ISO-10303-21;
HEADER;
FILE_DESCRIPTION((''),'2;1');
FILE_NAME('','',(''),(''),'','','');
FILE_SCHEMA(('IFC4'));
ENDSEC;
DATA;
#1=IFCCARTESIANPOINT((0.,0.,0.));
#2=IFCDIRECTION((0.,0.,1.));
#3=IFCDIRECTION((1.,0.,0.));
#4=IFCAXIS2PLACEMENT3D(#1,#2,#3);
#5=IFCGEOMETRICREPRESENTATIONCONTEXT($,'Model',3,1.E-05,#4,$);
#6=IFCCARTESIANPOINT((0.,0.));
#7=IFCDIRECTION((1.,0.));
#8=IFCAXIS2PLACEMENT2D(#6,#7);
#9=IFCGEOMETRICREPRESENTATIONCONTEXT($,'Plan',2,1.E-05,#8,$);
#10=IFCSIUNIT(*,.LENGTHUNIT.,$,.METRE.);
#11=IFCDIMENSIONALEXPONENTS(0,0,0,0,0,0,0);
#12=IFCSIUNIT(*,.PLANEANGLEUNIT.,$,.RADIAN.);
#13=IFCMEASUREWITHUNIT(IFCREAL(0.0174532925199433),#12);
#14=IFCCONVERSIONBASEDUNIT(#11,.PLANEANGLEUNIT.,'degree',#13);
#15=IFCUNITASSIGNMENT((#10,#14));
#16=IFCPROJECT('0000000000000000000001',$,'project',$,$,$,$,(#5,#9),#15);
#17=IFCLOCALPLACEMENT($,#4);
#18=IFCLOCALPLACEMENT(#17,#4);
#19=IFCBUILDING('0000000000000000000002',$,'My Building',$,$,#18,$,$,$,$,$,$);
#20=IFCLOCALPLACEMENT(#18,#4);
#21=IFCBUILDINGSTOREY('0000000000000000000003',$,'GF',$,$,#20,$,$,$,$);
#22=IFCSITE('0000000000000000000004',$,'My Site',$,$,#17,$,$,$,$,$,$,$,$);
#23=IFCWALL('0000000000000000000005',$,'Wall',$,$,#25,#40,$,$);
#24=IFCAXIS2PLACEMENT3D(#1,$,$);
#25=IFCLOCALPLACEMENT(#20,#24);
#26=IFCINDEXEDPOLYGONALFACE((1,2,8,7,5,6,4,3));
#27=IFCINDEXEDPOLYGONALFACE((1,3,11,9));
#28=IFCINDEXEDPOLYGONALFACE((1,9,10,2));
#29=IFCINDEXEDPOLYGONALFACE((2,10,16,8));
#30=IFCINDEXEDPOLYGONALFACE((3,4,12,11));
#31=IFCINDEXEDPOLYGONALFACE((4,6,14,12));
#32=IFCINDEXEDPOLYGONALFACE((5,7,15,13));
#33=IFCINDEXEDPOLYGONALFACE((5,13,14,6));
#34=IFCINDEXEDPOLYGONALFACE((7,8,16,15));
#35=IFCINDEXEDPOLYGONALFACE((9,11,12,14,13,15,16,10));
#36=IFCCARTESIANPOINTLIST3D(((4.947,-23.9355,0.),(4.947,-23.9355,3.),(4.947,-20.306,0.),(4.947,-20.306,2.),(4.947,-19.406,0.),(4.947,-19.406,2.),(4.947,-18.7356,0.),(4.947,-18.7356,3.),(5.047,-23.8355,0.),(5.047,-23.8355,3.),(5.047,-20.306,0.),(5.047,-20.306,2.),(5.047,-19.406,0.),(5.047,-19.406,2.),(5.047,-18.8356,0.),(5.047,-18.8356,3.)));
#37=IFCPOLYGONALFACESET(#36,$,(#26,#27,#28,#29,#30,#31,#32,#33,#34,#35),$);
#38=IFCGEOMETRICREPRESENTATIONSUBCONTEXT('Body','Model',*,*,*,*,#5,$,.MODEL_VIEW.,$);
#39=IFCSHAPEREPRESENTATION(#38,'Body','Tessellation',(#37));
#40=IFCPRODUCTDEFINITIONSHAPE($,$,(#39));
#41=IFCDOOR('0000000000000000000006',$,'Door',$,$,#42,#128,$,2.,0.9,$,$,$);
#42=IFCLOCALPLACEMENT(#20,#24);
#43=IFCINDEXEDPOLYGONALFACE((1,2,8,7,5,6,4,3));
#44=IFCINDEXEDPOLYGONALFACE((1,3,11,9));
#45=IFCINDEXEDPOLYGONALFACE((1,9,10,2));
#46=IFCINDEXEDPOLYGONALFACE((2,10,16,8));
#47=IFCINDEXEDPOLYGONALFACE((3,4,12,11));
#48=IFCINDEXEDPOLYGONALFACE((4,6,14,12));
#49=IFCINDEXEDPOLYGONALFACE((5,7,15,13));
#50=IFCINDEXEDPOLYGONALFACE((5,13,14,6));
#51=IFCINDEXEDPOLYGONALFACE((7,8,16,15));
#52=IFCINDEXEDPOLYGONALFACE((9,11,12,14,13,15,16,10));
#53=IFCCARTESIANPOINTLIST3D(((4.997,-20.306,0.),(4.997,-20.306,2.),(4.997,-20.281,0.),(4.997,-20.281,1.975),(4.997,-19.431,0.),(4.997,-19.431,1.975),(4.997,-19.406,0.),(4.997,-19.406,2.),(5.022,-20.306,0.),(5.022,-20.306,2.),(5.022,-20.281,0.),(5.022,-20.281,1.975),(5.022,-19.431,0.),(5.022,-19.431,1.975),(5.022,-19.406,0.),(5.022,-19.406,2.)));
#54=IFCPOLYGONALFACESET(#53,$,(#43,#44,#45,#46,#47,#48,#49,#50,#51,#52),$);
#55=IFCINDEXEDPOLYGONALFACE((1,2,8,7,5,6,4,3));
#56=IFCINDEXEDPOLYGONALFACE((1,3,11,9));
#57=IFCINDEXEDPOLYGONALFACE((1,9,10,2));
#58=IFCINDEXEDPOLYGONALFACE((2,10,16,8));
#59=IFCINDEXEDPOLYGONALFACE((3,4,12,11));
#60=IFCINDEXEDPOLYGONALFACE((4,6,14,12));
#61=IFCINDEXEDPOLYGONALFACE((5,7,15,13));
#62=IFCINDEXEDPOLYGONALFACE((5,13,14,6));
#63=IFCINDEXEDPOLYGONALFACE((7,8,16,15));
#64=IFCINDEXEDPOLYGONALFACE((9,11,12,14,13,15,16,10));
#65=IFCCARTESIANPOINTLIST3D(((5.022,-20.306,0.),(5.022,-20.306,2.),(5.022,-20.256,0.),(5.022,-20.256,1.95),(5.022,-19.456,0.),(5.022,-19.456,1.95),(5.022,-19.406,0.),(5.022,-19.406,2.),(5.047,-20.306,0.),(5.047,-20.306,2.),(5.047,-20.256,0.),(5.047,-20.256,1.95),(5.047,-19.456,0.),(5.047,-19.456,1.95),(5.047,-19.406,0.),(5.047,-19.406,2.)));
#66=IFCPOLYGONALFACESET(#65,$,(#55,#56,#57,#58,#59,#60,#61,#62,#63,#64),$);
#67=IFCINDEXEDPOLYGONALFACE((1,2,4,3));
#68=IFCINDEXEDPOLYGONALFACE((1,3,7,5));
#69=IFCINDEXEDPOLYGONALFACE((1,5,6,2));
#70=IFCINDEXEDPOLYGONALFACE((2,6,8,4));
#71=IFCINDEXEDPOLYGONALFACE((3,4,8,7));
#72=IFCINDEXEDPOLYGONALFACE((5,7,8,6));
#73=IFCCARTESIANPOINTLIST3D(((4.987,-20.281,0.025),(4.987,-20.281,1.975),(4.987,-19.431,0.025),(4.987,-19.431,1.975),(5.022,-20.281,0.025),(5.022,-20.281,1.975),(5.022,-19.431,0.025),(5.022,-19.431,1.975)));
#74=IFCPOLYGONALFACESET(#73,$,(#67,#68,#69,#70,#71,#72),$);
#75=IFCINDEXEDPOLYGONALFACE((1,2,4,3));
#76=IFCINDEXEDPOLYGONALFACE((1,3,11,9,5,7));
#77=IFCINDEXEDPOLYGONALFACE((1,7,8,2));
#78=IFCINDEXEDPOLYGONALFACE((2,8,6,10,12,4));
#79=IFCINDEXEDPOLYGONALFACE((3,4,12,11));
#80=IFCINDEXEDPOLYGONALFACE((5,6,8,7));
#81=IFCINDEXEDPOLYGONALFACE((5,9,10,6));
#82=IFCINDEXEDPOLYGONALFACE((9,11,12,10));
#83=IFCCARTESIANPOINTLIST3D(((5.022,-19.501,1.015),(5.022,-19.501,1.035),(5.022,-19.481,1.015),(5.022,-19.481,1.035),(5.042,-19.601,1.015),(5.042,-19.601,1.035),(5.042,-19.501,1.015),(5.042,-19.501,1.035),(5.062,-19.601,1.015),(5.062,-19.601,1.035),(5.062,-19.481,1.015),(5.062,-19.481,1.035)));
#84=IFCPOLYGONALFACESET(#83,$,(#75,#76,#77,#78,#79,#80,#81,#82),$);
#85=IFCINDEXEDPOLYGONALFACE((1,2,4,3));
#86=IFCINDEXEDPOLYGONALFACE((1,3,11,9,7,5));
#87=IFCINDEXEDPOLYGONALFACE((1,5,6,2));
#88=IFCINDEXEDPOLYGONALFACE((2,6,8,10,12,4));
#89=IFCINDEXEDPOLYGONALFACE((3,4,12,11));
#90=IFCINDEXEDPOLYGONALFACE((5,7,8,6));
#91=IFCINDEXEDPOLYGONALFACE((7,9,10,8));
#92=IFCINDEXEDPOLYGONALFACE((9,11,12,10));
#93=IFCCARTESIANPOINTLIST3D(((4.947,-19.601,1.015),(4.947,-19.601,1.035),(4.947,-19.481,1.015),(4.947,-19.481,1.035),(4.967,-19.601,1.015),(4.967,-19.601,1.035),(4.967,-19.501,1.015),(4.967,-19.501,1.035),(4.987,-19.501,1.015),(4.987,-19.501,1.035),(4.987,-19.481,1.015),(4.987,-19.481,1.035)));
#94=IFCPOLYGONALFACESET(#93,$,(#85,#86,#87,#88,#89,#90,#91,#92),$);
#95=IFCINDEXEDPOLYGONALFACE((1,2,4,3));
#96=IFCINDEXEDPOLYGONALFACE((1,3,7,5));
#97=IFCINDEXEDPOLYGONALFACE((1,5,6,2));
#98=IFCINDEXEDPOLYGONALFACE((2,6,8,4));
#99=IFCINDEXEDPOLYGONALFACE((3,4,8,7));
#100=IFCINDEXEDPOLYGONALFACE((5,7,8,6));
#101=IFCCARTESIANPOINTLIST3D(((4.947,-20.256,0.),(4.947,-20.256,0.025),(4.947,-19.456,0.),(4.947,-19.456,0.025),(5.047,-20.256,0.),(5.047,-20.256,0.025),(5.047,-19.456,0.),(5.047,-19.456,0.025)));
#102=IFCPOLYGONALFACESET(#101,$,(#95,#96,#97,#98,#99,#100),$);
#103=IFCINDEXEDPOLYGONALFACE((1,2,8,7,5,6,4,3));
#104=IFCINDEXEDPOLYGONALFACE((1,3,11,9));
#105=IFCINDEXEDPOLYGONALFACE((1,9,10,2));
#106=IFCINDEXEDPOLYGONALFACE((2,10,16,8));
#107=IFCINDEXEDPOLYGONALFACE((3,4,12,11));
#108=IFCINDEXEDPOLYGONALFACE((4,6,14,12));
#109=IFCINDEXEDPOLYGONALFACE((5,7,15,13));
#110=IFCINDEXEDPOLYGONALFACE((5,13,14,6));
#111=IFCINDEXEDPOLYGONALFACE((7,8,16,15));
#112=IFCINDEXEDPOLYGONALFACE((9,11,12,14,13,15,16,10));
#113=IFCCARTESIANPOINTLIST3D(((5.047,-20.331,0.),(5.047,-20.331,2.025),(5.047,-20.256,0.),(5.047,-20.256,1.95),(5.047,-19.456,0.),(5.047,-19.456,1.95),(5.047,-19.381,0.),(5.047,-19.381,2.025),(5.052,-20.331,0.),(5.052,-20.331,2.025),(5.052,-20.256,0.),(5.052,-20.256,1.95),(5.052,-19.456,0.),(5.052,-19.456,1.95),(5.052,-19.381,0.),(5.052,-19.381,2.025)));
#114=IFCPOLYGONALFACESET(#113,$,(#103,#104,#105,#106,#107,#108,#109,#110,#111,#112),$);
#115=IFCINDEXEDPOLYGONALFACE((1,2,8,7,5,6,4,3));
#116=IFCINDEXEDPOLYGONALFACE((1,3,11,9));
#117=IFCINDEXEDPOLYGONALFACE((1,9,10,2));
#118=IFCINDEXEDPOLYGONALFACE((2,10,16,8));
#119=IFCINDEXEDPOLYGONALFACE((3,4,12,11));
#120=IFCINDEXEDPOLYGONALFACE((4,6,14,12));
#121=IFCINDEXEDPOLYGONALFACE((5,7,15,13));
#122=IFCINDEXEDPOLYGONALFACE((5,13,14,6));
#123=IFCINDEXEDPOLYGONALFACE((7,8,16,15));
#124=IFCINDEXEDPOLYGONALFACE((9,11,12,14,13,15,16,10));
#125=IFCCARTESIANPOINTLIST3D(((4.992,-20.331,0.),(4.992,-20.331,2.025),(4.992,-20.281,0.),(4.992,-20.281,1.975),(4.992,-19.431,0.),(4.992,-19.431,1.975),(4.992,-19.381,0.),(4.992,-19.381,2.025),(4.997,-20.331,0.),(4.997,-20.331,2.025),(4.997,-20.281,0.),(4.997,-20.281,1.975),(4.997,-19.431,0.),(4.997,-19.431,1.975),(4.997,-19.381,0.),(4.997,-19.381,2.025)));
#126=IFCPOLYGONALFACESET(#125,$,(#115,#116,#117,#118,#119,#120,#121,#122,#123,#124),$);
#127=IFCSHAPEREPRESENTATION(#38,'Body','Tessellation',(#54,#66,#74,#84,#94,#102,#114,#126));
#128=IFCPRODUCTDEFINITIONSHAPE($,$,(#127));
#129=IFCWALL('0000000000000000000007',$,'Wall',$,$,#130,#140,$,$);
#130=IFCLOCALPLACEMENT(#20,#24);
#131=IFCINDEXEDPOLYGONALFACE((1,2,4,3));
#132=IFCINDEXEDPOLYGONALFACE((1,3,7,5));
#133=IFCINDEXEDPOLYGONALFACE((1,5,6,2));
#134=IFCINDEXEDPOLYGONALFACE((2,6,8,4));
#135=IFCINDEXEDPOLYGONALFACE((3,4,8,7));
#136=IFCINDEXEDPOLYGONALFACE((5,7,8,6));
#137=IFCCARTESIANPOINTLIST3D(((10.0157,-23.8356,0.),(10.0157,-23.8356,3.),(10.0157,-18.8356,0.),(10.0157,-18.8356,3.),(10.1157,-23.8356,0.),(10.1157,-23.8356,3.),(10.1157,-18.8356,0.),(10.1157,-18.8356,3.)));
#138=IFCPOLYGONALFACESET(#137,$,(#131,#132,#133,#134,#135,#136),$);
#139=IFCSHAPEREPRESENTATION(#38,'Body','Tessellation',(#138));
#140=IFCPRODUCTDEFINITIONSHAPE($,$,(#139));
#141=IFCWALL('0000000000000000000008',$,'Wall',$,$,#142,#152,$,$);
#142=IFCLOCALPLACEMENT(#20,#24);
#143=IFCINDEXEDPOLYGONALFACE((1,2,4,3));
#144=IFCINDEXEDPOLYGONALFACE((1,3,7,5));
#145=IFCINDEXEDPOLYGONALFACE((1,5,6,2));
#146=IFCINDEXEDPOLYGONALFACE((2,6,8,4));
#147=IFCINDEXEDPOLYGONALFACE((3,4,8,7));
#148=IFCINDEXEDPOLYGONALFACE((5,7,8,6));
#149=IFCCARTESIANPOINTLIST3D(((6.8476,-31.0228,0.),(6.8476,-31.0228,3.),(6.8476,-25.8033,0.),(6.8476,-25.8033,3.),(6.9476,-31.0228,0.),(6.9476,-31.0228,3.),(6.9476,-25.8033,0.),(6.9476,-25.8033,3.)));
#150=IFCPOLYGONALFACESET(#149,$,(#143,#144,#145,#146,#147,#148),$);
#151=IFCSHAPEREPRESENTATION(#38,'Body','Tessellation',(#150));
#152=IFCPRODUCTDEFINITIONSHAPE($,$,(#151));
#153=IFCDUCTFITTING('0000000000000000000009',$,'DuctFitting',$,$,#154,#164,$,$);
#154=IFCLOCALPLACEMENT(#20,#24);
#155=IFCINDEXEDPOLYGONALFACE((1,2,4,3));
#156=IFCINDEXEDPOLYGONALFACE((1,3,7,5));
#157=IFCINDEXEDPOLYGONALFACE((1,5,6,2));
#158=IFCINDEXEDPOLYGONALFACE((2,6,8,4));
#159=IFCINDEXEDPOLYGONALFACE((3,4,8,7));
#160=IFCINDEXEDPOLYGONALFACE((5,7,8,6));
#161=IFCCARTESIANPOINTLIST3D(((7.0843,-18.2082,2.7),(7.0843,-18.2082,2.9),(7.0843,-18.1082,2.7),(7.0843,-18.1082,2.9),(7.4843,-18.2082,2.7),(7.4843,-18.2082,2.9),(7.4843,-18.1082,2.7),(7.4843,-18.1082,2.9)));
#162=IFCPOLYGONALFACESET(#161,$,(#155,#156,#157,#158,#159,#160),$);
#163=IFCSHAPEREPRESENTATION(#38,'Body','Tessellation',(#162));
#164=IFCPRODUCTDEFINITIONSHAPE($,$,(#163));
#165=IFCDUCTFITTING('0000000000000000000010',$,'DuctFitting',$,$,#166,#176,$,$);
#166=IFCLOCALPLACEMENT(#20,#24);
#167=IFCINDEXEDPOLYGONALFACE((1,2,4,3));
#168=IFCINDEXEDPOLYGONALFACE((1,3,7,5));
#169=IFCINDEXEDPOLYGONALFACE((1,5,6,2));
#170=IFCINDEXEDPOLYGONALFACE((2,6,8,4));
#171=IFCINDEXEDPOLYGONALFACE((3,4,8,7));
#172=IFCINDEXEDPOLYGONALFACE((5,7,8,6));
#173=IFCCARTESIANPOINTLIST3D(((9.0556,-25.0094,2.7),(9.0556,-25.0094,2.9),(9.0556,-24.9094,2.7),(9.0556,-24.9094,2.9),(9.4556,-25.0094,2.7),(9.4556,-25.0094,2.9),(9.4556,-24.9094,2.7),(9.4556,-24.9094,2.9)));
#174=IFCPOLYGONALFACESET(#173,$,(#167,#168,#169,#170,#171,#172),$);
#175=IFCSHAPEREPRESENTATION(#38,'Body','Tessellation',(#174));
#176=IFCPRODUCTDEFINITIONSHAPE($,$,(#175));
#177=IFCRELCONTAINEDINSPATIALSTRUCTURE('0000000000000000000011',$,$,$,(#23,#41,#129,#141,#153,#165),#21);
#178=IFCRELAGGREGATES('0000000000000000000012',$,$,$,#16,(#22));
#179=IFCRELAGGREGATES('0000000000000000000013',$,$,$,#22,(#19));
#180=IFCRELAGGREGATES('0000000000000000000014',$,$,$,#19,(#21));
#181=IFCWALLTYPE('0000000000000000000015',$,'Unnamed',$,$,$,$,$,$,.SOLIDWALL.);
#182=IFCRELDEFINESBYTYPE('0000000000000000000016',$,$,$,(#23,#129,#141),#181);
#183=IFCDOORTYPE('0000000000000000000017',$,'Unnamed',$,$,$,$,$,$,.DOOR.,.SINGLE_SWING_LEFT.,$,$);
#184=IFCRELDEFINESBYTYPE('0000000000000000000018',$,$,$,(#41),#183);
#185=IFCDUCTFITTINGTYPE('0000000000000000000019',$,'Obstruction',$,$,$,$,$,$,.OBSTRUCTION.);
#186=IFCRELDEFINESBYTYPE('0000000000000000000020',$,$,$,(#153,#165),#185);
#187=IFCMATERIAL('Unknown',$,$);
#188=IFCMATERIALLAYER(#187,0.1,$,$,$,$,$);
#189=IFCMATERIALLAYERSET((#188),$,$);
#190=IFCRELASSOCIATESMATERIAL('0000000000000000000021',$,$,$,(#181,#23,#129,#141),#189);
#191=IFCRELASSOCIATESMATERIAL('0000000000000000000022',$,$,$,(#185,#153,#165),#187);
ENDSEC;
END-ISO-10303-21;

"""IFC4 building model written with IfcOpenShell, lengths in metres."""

from ifc_helpers import new_model, entity, si_unit, converted_unit, frame, origin_with_axes, origin_2d_with_axis, place, context, subcontext, project, spatial, line, indexed_curve, rectangle, outline, extrude, shape, source, transform, mapped, material, layer, layer_set, layer_usage, material_profile, profile_set, profile_usage, type_object, type_shapes, element, fill, save


model = new_model("IFC4")

# Units and contexts
model_context = context("Model", 3, precision=1e-05, world=origin_with_axes())
plan_context = context("Plan", 2, precision=1e-05, world=origin_2d_with_axis())
body_context_1 = subcontext(model_context, "Body", "Model", "MODEL_VIEW")
body_context_2 = subcontext(plan_context, "Body", "Plan", "PLAN_VIEW")
ifc_project = project(units=[si_unit("LENGTHUNIT", "METRE"), converted_unit("PLANEANGLEUNIT", "degree", entity("IfcReal", 0.0174532925199433), si_unit("PLANEANGLEUNIT", "RADIAN"), dimensions=[0, 0, 0, 0, 0, 0, 0])], contexts=[model_context, plan_context])

# Site, building, storey
site_placement = place(None, origin_with_axes())
site = spatial("IfcSite", under=ifc_project, at=site_placement, Name="My Site")
building_placement = place(site_placement, origin_with_axes())
building = spatial("IfcBuilding", under=site, at=building_placement, Name="My Building")
storey_placement = place(building_placement, origin_with_axes())
storey = spatial("IfcBuildingStorey", under=building, at=storey_placement, Name="GF")

# Shared definitions
ifc_material = material(Name="Unknown")

# Shared definitions
ifc_layer_1 = layer(ifc_material, 0.1)
ifc_layer_set_1 = layer_set([ifc_layer_1])
wall_type = type_object("IfcWallType", Name="Unnamed", PredefinedType="SOLIDWALL", material=ifc_layer_set_1)

# Shared definitions
shared_shape_1 = source(origin_with_axes(), body_context_1, "Body", "SweptSolid", [
    extrude(outline(indexed_curve([(0.0, 0.0), (0.9, 0.0), (0.9, 2.0), (0.0, 2.0)], segments=[line(1, 2, 3, 4, 1)])), frame((0.0, -0.6, 0.0), z_axis=(0.0, -1.0, 0.0), x_axis=(1.0, 0.0, 0.0)), (0.0, 0.0, -1.0), 1.2),
])
door_type = type_object("IfcDoorType", Name="Unnamed", OperationType="SINGLE_SWING_LEFT", PredefinedType="DOOR")
shared_shape_2 = source(origin_with_axes(), body_context_1, "Body", "SweptSolid", [
    extrude(outline(indexed_curve([(0.0, 0.0), (0.0, 2.0), (0.9, 2.0), (0.9, 0.0), (0.875, 0.0), (0.875, 1.975), (0.025, 1.975), (0.025, 0.0)], segments=[line(1, 2, 3, 4, 5, 6, 7, 8, 1)])), frame((0.0, 0.025, 0.0), z_axis=(0.0, -1.0, 0.0), x_axis=(1.0, 0.0, 0.0)), (0.0, 0.0, -1.0), 0.025),
    extrude(outline(indexed_curve([(0.0, 0.0), (0.0, 2.0), (0.9, 2.0), (0.9, 0.0), (0.85, 0.0), (0.85, 1.95), (0.05, 1.95), (0.05, 0.0)], segments=[line(1, 2, 3, 4, 5, 6, 7, 8, 1)])), frame((0.0, 0.0, 0.0), z_axis=(0.0, -1.0, 0.0), x_axis=(1.0, 0.0, 0.0)), (0.0, 0.0, -1.0), 0.025),
    extrude(outline(indexed_curve([(0.0, 0.0), (0.85, 0.0), (0.85, 0.035), (0.0, 0.035)], segments=[line(1, 2, 3, 4, 1)])), frame((0.025, 0.025, 0.025), z_axis=(0.0, 0.0, 1.0), x_axis=(1.0, 0.0, 0.0)), (0.0, 0.0, 1.0), 1.95),
    extrude(outline(indexed_curve([(0.0, 0.0), (0.0, -0.04), (-0.12, -0.04), (-0.12, -0.02), (-0.02, -0.02), (-0.02, 0.0)], segments=[line(1, 2, 3, 4, 5, 6, 1)])), frame((0.825, 0.025, 1.015), z_axis=(0.0, 0.0, 1.0), x_axis=(1.0, 0.0, 0.0)), (0.0, 0.0, 1.0), 0.02),
    extrude(outline(indexed_curve([(0.0, 0.0), (0.0, 0.04), (-0.12, 0.04), (-0.12, 0.02), (-0.02, 0.02), (-0.02, 0.0)], segments=[line(1, 2, 3, 4, 5, 6, 1)])), frame((0.825, 0.06, 1.015), z_axis=(0.0, 0.0, 1.0), x_axis=(1.0, 0.0, 0.0)), (0.0, 0.0, 1.0), 0.02),
    extrude(outline(indexed_curve([(0.0, 0.0), (0.8, 0.0), (0.8, 0.1), (0.0, 0.1)], segments=[line(1, 2, 3, 4, 1)])), frame((0.05, 0.0, 0.0), z_axis=(0.0, 0.0, 1.0), x_axis=(1.0, 0.0, 0.0)), (0.0, 0.0, 1.0), 0.025),
    extrude(outline(indexed_curve([(0.0, 0.0), (0.0, 2.025), (0.95, 2.025), (0.95, 0.0), (0.875, 0.0), (0.875, 1.95), (0.075, 1.95), (0.075, 0.0)], segments=[line(1, 2, 3, 4, 5, 6, 7, 8, 1)])), frame((-0.025, -0.005, 0.0), z_axis=(0.0, -1.0, 0.0), x_axis=(1.0, 0.0, 0.0)), (0.0, 0.0, -1.0), 0.005),
    extrude(outline(indexed_curve([(0.0, 0.0), (0.0, 2.025), (0.95, 2.025), (0.95, 0.0), (0.9, 0.0), (0.9, 1.975), (0.05, 1.975), (0.05, 0.0)], segments=[line(1, 2, 3, 4, 5, 6, 7, 8, 1)])), frame((-0.025, 0.05, 0.0), z_axis=(0.0, -1.0, 0.0), x_axis=(1.0, 0.0, 0.0)), (0.0, 0.0, -1.0), 0.005),
])
shared_shape_3 = source(origin_with_axes(), body_context_2, "Body", "Curve2D", [
    entity("IfcIndexedPolyCurve", entity("IfcCartesianPointList2D", [[0.0, 0.0], [0.0, 0.05], [0.025, 0.05], [0.025, 0.025], [0.05, 0.025], [0.05, 0.0]]), [entity("IfcLineIndex", [1, 2, 3, 4, 5, 6, 1])]),
    entity("IfcIndexedPolyCurve", entity("IfcCartesianPointList2D", [[0.9, 0.0], [0.9, 0.05], [0.875, 0.05], [0.875, 0.025], [0.85, 0.025], [0.85, 0.0]]), [entity("IfcLineIndex", [1, 2, 3, 4, 5, 6, 1])]),
    entity("IfcTrimmedCurve", entity("IfcEllipse", entity("IfcAxis2Placement2D", entity("IfcCartesianPoint", [0.06, 0.05]), entity("IfcDirection", [1.0, 0.0])), 0.815, 0.85), [entity("IfcCartesianPoint", [0.875, 0.05])], [entity("IfcCartesianPoint", [0.06, 0.9])], True, "CARTESIAN"),
    entity("IfcIndexedPolyCurve", entity("IfcCartesianPointList2D", [[0.025, 0.05], [0.06, 0.05], [0.06, 0.9], [0.025, 0.9]]), [entity("IfcLineIndex", [1, 2, 3, 4, 1])]),
])
type_shapes(door_type, [shared_shape_2, shared_shape_3])

# Wall, opening, door
ifc_layer_usage_1 = layer_usage(ifc_layer_set_1, "AXIS2", "POSITIVE", 0.0)
wall_1_placement = place(storey_placement, frame((5.047, -23.8355, 0.0), z_axis=(0.0, 0.0, 1.0), x_axis=(0.0, 1.0, 0.0)))
wall_1 = element("IfcWall", 1, at=wall_1_placement, inside=storey, type_object=wall_type, material=ifc_layer_usage_1, Name="Wall", context=body_context_1, shape_type="SweptSolid", body=[
    extrude(outline(indexed_curve([(0.0, 0.0), (-0.1, 0.1), (5.1, 0.1), (5.0, 0.0)], segments=[line(1, 2, 3, 4, 1)])), origin_with_axes(), (0.0, 0.0, 1.0), 3.0),
])
opening_1_placement = place(wall_1_placement, frame((3.5295, 0.0, 0.0), z_axis=(0.0, 0.0, 1.0), x_axis=(1.0, 0.0, 0.0)))
opening_1 = element("IfcOpeningElement", 2, at=opening_1_placement, cuts=wall_1, PredefinedType="OPENING", context=body_context_1, shape_type="MappedRepresentation", body=[
    mapped(shared_shape_1, transform((0.0, 0.0, 0.0), x_axis=(1.0, 0.0, 0.0), y_axis=(0.0, 1.0, 0.0), z_axis=(0.0, 0.0, 1.0), scale=1.0)),
])
door_1_placement = place(opening_1_placement, frame((0.0, 0.0, 0.0), z_axis=(0.0, 0.0, 1.0), x_axis=(1.0, 0.0, 0.0)))
door_1 = element("IfcDoor", 3, at=door_1_placement, inside=storey, type_object=door_type, Name="Door", OverallHeight=2.0, OverallWidth=0.9, shapes=[
    shape(body_context_1, "Body", "MappedRepresentation", [mapped(shared_shape_2, transform((0.0, 0.0, 0.0), x_axis=(1.0, 0.0, 0.0), y_axis=(0.0, 1.0, 0.0), z_axis=(0.0, 0.0, 1.0), scale=1.0))]),
    shape(body_context_2, "Body", "MappedRepresentation", [mapped(shared_shape_3, transform((0.0, 0.0, 0.0), x_axis=(1.0, 0.0, 0.0), y_axis=(0.0, 1.0, 0.0), z_axis=(0.0, 0.0, 1.0), scale=1.0))]),
])
fill(opening_1, door_1)

# Walls
ifc_layer_usage_2 = layer_usage(ifc_layer_set_1, "AXIS2", "POSITIVE", 0.0)
wall_2_placement = place(storey_placement, frame((10.0157, -18.8356, 0.0), z_axis=(0.0, 0.0, 1.0), x_axis=(0.0, -1.0, 0.0)))
element("IfcWall", 4, at=wall_2_placement, inside=storey, type_object=wall_type, material=ifc_layer_usage_2, Name="Wall", context=body_context_1, shape_type="SweptSolid", body=[
    extrude(outline(indexed_curve([(0.0, 0.0), (0.0, 0.1), (5.0, 0.1), (5.0, 0.0)], segments=[line(1, 2, 3, 4, 1)])), origin_with_axes(), (0.0, 0.0, 1.0), 3.0),
])
ifc_layer_usage_3 = layer_usage(ifc_layer_set_1, "AXIS2", "POSITIVE", 0.0)
wall_3_placement = place(storey_placement, frame((6.8476, -25.8033, 0.0), z_axis=(0.0, 0.0, 1.0), x_axis=(0.0, -1.0, 0.0)))
element("IfcWall", 5, at=wall_3_placement, inside=storey, type_object=wall_type, material=ifc_layer_usage_3, Name="Wall", context=body_context_1, shape_type="SweptSolid", body=[
    extrude(outline(indexed_curve([(0.0, 0.0), (0.0, 0.1), (5.2195, 0.1), (5.2195, 0.0)], segments=[line(1, 2, 3, 4, 1)])), origin_with_axes(), (0.0, 0.0, 1.0), 3.0),
])

# Duct fittings
ifc_material_profile = material_profile(ifc_material, rectangle(XDim=0.4, YDim=0.2))
ifc_profile_set = profile_set([ifc_material_profile])
ifc_profile_usage_1 = profile_usage(ifc_profile_set, cardinal=5)
duct_fitting_type = type_object("IfcDuctFittingType", Name="Obstruction", PredefinedType="OBSTRUCTION", material=ifc_profile_set)
duct_fitting_1_placement = place(storey_placement, frame((7.2843, -18.2082, 2.8), z_axis=(0.0, 1.0, 0.0), x_axis=(-1.0, 0.0, 0.0)))
element("IfcDuctFitting", 6, at=duct_fitting_1_placement, inside=storey, type_object=duct_fitting_type, material=ifc_profile_usage_1, Name="DuctFitting", context=body_context_1, shape_type="SweptSolid", body=[
    extrude(rectangle(XDim=0.4, YDim=0.2), origin_with_axes(), (0.0, 0.0, 1.0), 0.1),
])
ifc_profile_usage_2 = profile_usage(ifc_profile_set, cardinal=5)
duct_fitting_2_placement = place(storey_placement, frame((9.2556, -25.0094, 2.8), z_axis=(0.0, 1.0, 0.0), x_axis=(-1.0, 0.0, 0.0)))
element("IfcDuctFitting", 7, at=duct_fitting_2_placement, inside=storey, type_object=duct_fitting_type, material=ifc_profile_usage_2, Name="DuctFitting", context=body_context_1, shape_type="SweptSolid", body=[
    extrude(rectangle(XDim=0.4, YDim=0.2), origin_with_axes(), (0.0, 0.0, 1.0), 0.1),
])

save(model, "model.ifc")
